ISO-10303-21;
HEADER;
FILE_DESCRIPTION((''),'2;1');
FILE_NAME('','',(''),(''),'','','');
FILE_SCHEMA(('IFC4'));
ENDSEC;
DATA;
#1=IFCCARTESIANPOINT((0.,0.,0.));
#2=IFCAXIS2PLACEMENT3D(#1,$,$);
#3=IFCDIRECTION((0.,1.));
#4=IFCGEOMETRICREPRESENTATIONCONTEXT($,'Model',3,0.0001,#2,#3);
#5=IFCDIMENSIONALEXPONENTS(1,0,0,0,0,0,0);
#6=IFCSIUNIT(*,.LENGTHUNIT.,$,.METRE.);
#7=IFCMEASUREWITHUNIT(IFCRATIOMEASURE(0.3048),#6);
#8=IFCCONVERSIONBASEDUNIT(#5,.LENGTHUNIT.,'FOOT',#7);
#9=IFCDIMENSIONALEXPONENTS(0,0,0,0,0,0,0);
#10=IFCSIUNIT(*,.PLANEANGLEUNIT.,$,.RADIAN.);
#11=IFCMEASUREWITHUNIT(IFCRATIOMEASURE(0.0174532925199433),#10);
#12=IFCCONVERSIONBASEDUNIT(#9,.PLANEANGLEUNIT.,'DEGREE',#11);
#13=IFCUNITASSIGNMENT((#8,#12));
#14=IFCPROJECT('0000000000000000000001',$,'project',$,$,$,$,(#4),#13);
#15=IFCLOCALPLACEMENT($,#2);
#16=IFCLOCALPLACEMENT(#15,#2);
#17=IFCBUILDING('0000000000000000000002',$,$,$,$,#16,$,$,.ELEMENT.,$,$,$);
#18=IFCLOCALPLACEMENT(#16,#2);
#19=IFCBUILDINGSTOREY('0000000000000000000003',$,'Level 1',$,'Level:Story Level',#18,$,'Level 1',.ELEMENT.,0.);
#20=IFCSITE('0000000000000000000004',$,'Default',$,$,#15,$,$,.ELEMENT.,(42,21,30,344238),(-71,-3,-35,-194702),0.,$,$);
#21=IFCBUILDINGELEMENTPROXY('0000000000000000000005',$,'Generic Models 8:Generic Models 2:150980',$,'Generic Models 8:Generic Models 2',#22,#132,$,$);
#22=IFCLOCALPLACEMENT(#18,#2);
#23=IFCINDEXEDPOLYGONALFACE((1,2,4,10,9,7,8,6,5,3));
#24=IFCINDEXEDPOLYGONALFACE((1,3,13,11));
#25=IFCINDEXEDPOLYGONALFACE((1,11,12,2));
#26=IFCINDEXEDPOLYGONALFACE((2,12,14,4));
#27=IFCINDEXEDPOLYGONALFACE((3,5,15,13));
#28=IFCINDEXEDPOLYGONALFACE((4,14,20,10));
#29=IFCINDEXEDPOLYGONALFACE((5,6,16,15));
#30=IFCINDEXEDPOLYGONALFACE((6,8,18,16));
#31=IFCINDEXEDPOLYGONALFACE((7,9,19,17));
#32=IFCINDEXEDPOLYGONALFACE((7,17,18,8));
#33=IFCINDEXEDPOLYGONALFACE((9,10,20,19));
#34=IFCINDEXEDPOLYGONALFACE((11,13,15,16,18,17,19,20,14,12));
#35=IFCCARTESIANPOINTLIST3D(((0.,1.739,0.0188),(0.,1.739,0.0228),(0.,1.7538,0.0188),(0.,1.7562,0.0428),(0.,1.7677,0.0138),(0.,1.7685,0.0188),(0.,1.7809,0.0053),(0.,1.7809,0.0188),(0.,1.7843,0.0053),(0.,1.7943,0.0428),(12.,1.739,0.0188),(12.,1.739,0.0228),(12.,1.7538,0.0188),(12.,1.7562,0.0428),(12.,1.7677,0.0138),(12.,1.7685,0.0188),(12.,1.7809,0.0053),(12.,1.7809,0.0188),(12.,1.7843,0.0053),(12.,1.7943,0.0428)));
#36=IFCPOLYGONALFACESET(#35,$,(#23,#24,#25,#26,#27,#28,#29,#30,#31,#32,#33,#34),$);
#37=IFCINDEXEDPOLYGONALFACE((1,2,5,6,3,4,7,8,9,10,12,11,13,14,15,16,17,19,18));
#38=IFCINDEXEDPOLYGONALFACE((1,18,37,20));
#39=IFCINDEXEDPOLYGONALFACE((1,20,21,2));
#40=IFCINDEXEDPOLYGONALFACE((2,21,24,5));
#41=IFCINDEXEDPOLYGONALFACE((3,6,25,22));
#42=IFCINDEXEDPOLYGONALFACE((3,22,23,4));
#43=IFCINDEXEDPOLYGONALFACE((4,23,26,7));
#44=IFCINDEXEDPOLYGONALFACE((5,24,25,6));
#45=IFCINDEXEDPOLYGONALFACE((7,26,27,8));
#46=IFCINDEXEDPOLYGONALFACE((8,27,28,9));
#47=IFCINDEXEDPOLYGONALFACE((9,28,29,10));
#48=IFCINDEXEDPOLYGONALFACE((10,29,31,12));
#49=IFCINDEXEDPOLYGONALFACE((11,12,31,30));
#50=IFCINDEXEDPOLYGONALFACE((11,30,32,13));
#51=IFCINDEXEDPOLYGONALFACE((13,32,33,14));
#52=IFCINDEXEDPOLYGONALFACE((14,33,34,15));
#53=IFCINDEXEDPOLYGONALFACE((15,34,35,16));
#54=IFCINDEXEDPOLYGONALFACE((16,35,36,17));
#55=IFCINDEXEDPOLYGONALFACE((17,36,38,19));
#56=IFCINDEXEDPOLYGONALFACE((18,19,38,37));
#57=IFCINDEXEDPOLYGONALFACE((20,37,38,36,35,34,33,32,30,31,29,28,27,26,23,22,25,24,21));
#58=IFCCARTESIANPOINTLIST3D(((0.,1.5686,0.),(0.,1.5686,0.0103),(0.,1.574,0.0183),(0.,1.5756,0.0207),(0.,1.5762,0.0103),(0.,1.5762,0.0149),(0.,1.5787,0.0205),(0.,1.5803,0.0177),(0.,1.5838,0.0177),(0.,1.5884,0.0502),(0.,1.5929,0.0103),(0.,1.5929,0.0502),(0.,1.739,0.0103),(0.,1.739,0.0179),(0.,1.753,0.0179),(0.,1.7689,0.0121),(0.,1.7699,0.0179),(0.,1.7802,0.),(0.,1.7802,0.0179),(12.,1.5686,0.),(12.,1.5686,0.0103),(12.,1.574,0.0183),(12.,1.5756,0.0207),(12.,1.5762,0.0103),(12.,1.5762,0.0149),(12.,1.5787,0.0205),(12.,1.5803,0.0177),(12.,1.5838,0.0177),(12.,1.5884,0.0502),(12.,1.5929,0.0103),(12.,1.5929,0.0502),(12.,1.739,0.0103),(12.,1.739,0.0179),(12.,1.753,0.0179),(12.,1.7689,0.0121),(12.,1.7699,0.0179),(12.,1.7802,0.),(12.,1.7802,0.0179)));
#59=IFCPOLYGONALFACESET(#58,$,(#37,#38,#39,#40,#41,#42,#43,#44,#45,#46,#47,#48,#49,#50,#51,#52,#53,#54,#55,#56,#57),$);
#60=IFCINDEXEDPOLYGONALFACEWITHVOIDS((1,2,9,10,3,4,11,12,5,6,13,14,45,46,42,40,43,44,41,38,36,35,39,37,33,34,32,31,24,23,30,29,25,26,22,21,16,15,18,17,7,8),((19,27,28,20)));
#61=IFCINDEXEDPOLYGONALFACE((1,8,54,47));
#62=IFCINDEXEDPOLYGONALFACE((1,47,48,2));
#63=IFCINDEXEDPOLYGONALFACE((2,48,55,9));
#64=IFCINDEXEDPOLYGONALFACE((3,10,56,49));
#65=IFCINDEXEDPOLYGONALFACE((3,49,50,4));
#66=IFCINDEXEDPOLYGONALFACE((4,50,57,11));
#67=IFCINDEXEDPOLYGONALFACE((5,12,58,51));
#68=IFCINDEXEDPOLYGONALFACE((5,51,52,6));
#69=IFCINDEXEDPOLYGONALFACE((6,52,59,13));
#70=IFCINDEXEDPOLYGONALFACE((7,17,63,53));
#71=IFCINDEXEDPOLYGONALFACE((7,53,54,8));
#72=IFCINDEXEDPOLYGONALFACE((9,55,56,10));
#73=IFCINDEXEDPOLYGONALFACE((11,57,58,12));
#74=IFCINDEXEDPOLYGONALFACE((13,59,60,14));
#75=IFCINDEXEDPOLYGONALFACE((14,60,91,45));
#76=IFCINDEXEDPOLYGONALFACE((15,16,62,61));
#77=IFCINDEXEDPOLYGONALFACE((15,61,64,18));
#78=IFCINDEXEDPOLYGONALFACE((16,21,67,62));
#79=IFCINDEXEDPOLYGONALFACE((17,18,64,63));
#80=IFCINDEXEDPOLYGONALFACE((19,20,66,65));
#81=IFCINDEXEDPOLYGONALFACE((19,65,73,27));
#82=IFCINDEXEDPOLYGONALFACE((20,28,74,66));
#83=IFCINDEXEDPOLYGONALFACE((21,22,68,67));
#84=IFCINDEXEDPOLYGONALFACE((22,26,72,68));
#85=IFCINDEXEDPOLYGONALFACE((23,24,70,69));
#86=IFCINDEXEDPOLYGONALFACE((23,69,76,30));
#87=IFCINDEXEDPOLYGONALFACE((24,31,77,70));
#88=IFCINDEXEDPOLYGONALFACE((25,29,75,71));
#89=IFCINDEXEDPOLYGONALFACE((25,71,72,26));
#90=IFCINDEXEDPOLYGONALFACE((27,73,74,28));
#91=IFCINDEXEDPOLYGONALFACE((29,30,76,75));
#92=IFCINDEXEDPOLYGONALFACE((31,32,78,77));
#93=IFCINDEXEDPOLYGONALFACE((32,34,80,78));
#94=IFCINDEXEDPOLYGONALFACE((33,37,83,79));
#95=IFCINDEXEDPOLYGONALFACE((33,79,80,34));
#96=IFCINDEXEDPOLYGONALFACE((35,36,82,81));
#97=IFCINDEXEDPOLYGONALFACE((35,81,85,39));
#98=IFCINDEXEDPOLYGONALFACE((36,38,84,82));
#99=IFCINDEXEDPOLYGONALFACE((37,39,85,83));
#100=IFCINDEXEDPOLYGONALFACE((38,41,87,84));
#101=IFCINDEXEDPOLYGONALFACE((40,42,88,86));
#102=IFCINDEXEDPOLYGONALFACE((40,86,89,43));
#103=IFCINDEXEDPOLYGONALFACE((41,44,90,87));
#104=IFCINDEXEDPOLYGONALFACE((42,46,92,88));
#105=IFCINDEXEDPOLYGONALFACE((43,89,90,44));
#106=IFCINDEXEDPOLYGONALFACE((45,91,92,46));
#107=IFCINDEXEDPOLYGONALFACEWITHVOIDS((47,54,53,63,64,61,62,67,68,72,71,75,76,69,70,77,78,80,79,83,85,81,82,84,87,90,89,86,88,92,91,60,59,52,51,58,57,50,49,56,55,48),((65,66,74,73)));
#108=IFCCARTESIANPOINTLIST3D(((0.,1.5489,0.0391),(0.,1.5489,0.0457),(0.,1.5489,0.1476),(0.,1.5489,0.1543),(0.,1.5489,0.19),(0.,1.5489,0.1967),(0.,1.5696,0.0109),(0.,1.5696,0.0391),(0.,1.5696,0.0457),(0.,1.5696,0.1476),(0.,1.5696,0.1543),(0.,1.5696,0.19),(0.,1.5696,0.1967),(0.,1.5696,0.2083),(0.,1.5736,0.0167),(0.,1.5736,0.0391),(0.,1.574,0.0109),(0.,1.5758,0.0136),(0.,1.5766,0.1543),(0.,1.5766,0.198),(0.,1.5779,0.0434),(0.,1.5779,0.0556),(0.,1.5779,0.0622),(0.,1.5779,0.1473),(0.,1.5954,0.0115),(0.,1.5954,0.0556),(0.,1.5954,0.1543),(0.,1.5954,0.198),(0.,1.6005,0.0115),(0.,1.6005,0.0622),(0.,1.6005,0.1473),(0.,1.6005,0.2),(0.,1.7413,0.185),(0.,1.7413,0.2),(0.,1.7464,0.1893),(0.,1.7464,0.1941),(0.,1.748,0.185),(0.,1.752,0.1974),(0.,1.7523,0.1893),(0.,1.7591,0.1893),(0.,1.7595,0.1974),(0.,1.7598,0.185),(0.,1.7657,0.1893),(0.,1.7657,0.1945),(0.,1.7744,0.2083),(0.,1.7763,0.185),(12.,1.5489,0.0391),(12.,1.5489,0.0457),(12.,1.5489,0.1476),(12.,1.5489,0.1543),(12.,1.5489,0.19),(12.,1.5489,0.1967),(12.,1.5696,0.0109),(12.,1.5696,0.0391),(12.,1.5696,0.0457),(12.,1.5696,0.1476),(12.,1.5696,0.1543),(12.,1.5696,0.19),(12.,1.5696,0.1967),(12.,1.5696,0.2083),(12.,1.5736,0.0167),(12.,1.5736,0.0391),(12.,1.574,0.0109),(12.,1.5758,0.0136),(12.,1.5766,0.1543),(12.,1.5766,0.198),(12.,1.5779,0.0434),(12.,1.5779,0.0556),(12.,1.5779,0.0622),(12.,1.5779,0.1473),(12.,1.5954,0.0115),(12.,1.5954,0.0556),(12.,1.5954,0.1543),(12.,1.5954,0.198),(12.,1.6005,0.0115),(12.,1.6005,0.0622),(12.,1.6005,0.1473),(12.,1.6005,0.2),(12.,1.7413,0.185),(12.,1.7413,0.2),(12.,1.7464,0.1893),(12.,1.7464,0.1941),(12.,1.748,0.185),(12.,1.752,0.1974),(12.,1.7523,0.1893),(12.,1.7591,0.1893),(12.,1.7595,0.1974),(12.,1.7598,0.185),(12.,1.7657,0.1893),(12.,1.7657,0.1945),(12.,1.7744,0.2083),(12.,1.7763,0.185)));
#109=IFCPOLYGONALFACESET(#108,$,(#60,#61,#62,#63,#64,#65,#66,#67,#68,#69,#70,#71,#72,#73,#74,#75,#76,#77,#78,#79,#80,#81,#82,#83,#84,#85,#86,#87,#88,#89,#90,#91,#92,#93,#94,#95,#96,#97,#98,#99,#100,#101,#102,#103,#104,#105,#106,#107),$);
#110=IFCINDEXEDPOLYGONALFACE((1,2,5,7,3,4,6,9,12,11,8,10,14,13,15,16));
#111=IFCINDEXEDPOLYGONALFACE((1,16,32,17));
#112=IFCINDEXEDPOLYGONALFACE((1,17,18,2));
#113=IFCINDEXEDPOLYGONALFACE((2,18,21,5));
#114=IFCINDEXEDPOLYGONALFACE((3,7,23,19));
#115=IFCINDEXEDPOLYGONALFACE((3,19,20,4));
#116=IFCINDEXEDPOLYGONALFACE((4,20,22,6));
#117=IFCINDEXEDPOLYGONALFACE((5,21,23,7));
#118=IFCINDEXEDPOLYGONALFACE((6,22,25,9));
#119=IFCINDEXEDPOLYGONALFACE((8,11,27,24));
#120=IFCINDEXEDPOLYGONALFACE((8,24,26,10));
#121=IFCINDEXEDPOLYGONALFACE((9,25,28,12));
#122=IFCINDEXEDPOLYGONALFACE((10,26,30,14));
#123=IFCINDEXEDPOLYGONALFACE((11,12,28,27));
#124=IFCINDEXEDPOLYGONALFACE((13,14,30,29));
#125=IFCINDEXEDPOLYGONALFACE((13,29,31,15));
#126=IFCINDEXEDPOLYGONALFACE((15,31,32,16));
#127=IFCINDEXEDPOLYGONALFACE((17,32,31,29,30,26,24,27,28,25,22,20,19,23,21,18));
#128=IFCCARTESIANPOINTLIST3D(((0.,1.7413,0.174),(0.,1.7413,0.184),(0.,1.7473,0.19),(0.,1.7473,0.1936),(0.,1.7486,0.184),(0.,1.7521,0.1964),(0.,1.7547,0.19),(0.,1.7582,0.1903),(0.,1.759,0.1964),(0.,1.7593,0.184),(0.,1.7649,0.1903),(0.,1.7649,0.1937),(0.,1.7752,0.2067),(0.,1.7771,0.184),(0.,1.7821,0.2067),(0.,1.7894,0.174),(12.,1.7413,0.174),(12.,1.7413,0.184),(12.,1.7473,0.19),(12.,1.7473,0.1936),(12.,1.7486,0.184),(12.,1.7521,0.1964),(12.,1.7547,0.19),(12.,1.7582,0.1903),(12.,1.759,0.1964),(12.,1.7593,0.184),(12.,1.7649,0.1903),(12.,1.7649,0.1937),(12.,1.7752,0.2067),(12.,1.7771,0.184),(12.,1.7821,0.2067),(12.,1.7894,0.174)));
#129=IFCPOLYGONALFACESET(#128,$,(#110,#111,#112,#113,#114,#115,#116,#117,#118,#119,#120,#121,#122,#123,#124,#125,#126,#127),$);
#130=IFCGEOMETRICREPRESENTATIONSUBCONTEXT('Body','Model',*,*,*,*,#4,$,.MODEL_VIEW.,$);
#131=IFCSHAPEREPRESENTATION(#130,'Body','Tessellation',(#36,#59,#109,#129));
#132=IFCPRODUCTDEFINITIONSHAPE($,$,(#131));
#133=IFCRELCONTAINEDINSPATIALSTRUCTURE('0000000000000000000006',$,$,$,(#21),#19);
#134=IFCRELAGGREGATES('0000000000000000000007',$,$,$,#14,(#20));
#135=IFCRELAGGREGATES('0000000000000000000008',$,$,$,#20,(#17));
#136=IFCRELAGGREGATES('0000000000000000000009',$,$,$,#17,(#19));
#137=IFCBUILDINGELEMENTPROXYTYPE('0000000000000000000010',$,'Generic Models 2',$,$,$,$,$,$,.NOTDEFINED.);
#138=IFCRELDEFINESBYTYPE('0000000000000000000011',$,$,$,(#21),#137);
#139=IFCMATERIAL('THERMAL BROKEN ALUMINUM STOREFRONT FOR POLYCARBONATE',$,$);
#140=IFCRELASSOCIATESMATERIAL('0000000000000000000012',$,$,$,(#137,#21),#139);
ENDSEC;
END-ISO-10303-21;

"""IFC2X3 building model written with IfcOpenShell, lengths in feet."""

from ifc_helpers import new_model, entity, si_unit, converted_unit, direction, frame, origin, place, context, subcontext, project, spatial, polyline, outline, extrude, source, transform, mapped, material, type_object, type_shapes, element, save


model = new_model("IFC2X3")

# Units and contexts
model_context = context("Model", 3, precision=0.0001, world=origin(), true_north=direction((0.0, 1.0)))
body_context = subcontext(model_context, "Body", "Model", "MODEL_VIEW")
ifc_project = project(units=[converted_unit("LENGTHUNIT", "FOOT", entity("IfcRatioMeasure", 0.3048), si_unit("LENGTHUNIT", "METRE"), dimensions=[1, 0, 0, 0, 0, 0, 0]), converted_unit("PLANEANGLEUNIT", "DEGREE", entity("IfcRatioMeasure", 0.0174532925199433), si_unit("PLANEANGLEUNIT", "RADIAN"), dimensions=[0, 0, 0, 0, 0, 0, 0])], contexts=[model_context])

# Site, building, storey
site_placement = place(None, origin())
site = spatial("IfcSite", under=ifc_project, at=site_placement, Name="Default", CompositionType="ELEMENT", RefLatitude=(42, 21, 30, 344238), RefLongitude=(-71, -3, -35, -194702), RefElevation=0.0)
building_placement = place(site_placement, origin())
building = spatial("IfcBuilding", under=site, at=building_placement, CompositionType="ELEMENT")
storey_placement = place(building_placement, origin())
storey = spatial("IfcBuildingStorey", under=building, at=storey_placement, Name="Level 1", ObjectType="Level:Story Level", LongName="Level 1", CompositionType="ELEMENT", Elevation=0.0)

# Building element proxy
ifc_material = material(Name="THERMAL BROKEN ALUMINUM STOREFRONT FOR POLYCARBONATE")
building_element_proxy_type_1 = type_object("IfcBuildingElementProxyType", Name="Generic Models 2", PredefinedType="NOTDEFINED", material=ifc_material)
shared_shape_1 = source(origin(), body_context, "Body", "SweptSolid", [
    extrude(outline(polyline([(-0.0104, -0.0212), (0.0284, -0.0212), (0.0186, 0.0156), (-0.0052, 0.0271), (-0.009, 0.026), (-0.0051, 0.0117), (-0.0065, -0.003), (-0.0014, -0.0025), (0.0018, -0.0144), (-0.0113, -0.0179), (-0.0104, -0.0212)])), frame((-15.0475, 0.5792, -0.4887), z_axis=(1.0, 0.0, 0.0), x_axis=(0.0, 0.257663, 0.966235)), (0.0, 0.0, 1.0), 12.0),
    extrude(outline(polyline([(0.068, 0.0006), (0.0711, 0.0006), (0.0726, 0.0031), (0.0702, 0.0064), (0.07, 0.011), (0.0776, 0.0114), (0.0771, 0.0217), (-0.1343, 0.0107), (-0.1334, -0.0072), (-0.1231, -0.0066), (-0.1224, -0.0008), (-0.1062, -0.0058), (-0.0922, -0.005), (-0.0926, 0.0025), (0.0533, 0.0101), (0.0554, -0.0297), (0.0599, -0.0295), (0.0628, 0.0032), (0.0663, 0.0034), (0.068, 0.0006)])), frame((-15.0475, 0.4594, -0.4919), z_axis=(1.0, 0.0, 0.0), x_axis=(0.0, -0.998659, 0.051774)), (0.0, 0.0, 1.0), 12.0),
    extrude(outline(polyline([(-0.073, 0.107), (-0.058, 0.107), (-0.058, 0.1137), (-0.0623, 0.118), (-0.0623, 0.1121), (-0.0672, 0.1121), (-0.0704, 0.1177), (-0.0704, 0.1252), (-0.0675, 0.1315), (-0.0623, 0.1315), (-0.0623, 0.1248), (-0.058, 0.1255), (-0.058, 0.142), (-0.0814, 0.1401), (-0.0814, -0.0647), (-0.0697, -0.0647), (-0.0697, -0.0853), (-0.0631, -0.0853), (-0.0631, -0.0647), (-0.0273, -0.0647), (-0.0273, -0.0853), (-0.0207, -0.0853), (-0.0207, -0.0647), (0.0812, -0.0647), (0.0812, -0.0853), (0.0878, -0.0853), (0.0878, -0.0647), (0.1161, -0.0647), (0.1161, -0.0603), (0.1133, -0.0585), (0.1102, -0.0606), (0.0878, -0.0606), (0.0836, -0.0564), (0.0713, -0.0564), (0.0713, -0.0389), (0.1155, -0.0389), (0.1155, -0.0338), (0.0647, -0.0338), (0.0647, -0.0564), (-0.0203, -0.0564), (-0.0203, -0.0338), (-0.073, -0.0338), (-0.073, 0.107)]), holes=[polyline([(-0.0711, -0.0577), (-0.0711, -0.0389), (-0.0273, -0.0389), (-0.0273, -0.0577), (-0.0711, -0.0577)])]), frame((-15.0475, 0.447, -0.3825), z_axis=(1.0, 0.0, 0.0), x_axis=(0.0, 0.0, -1.0)), (0.0, 0.0, 1.0), 12.0),
    extrude(outline(polyline([(-0.0218, -0.0251), (0.0116, -0.0251), (0.0131, -0.0183), (-0.0094, -0.0153), (-0.0056, 0.0021), (0.0008, 0.0018), (-0.0006, -0.0047), (0.0027, -0.0054), (0.0066, -0.0003), (0.0081, 0.0064), (0.0064, 0.0118), (0.0029, 0.0126), (0.0013, 0.0053), (-0.0032, 0.0125), (-0.0017, 0.0197), (-0.0114, 0.0218), (-0.0218, -0.0251)])), frame((-15.0475, 0.5729, -0.3196), z_axis=(1.0, 0.0, 0.0), x_axis=(0.0, -0.217466, 0.976068)), (0.0, 0.0, 1.0), 12.0),
])
type_shapes(building_element_proxy_type_1, [shared_shape_1])
proxy_1_placement = place(storey_placement, frame((15.0475, 1.1873, 0.5095)))
element("IfcBuildingElementProxy", 1, at=proxy_1_placement, inside=storey, type_object=building_element_proxy_type_1, material=ifc_material, Name="Generic Models 8:Generic Models 2:150980", ObjectType="Generic Models 8:Generic Models 2", context=body_context, shape_type="MappedRepresentation", body=[
    mapped(shared_shape_1, transform((0.0, 0.0, 0.0), scale=1.0)),
])

save(model, "model.ifc")
